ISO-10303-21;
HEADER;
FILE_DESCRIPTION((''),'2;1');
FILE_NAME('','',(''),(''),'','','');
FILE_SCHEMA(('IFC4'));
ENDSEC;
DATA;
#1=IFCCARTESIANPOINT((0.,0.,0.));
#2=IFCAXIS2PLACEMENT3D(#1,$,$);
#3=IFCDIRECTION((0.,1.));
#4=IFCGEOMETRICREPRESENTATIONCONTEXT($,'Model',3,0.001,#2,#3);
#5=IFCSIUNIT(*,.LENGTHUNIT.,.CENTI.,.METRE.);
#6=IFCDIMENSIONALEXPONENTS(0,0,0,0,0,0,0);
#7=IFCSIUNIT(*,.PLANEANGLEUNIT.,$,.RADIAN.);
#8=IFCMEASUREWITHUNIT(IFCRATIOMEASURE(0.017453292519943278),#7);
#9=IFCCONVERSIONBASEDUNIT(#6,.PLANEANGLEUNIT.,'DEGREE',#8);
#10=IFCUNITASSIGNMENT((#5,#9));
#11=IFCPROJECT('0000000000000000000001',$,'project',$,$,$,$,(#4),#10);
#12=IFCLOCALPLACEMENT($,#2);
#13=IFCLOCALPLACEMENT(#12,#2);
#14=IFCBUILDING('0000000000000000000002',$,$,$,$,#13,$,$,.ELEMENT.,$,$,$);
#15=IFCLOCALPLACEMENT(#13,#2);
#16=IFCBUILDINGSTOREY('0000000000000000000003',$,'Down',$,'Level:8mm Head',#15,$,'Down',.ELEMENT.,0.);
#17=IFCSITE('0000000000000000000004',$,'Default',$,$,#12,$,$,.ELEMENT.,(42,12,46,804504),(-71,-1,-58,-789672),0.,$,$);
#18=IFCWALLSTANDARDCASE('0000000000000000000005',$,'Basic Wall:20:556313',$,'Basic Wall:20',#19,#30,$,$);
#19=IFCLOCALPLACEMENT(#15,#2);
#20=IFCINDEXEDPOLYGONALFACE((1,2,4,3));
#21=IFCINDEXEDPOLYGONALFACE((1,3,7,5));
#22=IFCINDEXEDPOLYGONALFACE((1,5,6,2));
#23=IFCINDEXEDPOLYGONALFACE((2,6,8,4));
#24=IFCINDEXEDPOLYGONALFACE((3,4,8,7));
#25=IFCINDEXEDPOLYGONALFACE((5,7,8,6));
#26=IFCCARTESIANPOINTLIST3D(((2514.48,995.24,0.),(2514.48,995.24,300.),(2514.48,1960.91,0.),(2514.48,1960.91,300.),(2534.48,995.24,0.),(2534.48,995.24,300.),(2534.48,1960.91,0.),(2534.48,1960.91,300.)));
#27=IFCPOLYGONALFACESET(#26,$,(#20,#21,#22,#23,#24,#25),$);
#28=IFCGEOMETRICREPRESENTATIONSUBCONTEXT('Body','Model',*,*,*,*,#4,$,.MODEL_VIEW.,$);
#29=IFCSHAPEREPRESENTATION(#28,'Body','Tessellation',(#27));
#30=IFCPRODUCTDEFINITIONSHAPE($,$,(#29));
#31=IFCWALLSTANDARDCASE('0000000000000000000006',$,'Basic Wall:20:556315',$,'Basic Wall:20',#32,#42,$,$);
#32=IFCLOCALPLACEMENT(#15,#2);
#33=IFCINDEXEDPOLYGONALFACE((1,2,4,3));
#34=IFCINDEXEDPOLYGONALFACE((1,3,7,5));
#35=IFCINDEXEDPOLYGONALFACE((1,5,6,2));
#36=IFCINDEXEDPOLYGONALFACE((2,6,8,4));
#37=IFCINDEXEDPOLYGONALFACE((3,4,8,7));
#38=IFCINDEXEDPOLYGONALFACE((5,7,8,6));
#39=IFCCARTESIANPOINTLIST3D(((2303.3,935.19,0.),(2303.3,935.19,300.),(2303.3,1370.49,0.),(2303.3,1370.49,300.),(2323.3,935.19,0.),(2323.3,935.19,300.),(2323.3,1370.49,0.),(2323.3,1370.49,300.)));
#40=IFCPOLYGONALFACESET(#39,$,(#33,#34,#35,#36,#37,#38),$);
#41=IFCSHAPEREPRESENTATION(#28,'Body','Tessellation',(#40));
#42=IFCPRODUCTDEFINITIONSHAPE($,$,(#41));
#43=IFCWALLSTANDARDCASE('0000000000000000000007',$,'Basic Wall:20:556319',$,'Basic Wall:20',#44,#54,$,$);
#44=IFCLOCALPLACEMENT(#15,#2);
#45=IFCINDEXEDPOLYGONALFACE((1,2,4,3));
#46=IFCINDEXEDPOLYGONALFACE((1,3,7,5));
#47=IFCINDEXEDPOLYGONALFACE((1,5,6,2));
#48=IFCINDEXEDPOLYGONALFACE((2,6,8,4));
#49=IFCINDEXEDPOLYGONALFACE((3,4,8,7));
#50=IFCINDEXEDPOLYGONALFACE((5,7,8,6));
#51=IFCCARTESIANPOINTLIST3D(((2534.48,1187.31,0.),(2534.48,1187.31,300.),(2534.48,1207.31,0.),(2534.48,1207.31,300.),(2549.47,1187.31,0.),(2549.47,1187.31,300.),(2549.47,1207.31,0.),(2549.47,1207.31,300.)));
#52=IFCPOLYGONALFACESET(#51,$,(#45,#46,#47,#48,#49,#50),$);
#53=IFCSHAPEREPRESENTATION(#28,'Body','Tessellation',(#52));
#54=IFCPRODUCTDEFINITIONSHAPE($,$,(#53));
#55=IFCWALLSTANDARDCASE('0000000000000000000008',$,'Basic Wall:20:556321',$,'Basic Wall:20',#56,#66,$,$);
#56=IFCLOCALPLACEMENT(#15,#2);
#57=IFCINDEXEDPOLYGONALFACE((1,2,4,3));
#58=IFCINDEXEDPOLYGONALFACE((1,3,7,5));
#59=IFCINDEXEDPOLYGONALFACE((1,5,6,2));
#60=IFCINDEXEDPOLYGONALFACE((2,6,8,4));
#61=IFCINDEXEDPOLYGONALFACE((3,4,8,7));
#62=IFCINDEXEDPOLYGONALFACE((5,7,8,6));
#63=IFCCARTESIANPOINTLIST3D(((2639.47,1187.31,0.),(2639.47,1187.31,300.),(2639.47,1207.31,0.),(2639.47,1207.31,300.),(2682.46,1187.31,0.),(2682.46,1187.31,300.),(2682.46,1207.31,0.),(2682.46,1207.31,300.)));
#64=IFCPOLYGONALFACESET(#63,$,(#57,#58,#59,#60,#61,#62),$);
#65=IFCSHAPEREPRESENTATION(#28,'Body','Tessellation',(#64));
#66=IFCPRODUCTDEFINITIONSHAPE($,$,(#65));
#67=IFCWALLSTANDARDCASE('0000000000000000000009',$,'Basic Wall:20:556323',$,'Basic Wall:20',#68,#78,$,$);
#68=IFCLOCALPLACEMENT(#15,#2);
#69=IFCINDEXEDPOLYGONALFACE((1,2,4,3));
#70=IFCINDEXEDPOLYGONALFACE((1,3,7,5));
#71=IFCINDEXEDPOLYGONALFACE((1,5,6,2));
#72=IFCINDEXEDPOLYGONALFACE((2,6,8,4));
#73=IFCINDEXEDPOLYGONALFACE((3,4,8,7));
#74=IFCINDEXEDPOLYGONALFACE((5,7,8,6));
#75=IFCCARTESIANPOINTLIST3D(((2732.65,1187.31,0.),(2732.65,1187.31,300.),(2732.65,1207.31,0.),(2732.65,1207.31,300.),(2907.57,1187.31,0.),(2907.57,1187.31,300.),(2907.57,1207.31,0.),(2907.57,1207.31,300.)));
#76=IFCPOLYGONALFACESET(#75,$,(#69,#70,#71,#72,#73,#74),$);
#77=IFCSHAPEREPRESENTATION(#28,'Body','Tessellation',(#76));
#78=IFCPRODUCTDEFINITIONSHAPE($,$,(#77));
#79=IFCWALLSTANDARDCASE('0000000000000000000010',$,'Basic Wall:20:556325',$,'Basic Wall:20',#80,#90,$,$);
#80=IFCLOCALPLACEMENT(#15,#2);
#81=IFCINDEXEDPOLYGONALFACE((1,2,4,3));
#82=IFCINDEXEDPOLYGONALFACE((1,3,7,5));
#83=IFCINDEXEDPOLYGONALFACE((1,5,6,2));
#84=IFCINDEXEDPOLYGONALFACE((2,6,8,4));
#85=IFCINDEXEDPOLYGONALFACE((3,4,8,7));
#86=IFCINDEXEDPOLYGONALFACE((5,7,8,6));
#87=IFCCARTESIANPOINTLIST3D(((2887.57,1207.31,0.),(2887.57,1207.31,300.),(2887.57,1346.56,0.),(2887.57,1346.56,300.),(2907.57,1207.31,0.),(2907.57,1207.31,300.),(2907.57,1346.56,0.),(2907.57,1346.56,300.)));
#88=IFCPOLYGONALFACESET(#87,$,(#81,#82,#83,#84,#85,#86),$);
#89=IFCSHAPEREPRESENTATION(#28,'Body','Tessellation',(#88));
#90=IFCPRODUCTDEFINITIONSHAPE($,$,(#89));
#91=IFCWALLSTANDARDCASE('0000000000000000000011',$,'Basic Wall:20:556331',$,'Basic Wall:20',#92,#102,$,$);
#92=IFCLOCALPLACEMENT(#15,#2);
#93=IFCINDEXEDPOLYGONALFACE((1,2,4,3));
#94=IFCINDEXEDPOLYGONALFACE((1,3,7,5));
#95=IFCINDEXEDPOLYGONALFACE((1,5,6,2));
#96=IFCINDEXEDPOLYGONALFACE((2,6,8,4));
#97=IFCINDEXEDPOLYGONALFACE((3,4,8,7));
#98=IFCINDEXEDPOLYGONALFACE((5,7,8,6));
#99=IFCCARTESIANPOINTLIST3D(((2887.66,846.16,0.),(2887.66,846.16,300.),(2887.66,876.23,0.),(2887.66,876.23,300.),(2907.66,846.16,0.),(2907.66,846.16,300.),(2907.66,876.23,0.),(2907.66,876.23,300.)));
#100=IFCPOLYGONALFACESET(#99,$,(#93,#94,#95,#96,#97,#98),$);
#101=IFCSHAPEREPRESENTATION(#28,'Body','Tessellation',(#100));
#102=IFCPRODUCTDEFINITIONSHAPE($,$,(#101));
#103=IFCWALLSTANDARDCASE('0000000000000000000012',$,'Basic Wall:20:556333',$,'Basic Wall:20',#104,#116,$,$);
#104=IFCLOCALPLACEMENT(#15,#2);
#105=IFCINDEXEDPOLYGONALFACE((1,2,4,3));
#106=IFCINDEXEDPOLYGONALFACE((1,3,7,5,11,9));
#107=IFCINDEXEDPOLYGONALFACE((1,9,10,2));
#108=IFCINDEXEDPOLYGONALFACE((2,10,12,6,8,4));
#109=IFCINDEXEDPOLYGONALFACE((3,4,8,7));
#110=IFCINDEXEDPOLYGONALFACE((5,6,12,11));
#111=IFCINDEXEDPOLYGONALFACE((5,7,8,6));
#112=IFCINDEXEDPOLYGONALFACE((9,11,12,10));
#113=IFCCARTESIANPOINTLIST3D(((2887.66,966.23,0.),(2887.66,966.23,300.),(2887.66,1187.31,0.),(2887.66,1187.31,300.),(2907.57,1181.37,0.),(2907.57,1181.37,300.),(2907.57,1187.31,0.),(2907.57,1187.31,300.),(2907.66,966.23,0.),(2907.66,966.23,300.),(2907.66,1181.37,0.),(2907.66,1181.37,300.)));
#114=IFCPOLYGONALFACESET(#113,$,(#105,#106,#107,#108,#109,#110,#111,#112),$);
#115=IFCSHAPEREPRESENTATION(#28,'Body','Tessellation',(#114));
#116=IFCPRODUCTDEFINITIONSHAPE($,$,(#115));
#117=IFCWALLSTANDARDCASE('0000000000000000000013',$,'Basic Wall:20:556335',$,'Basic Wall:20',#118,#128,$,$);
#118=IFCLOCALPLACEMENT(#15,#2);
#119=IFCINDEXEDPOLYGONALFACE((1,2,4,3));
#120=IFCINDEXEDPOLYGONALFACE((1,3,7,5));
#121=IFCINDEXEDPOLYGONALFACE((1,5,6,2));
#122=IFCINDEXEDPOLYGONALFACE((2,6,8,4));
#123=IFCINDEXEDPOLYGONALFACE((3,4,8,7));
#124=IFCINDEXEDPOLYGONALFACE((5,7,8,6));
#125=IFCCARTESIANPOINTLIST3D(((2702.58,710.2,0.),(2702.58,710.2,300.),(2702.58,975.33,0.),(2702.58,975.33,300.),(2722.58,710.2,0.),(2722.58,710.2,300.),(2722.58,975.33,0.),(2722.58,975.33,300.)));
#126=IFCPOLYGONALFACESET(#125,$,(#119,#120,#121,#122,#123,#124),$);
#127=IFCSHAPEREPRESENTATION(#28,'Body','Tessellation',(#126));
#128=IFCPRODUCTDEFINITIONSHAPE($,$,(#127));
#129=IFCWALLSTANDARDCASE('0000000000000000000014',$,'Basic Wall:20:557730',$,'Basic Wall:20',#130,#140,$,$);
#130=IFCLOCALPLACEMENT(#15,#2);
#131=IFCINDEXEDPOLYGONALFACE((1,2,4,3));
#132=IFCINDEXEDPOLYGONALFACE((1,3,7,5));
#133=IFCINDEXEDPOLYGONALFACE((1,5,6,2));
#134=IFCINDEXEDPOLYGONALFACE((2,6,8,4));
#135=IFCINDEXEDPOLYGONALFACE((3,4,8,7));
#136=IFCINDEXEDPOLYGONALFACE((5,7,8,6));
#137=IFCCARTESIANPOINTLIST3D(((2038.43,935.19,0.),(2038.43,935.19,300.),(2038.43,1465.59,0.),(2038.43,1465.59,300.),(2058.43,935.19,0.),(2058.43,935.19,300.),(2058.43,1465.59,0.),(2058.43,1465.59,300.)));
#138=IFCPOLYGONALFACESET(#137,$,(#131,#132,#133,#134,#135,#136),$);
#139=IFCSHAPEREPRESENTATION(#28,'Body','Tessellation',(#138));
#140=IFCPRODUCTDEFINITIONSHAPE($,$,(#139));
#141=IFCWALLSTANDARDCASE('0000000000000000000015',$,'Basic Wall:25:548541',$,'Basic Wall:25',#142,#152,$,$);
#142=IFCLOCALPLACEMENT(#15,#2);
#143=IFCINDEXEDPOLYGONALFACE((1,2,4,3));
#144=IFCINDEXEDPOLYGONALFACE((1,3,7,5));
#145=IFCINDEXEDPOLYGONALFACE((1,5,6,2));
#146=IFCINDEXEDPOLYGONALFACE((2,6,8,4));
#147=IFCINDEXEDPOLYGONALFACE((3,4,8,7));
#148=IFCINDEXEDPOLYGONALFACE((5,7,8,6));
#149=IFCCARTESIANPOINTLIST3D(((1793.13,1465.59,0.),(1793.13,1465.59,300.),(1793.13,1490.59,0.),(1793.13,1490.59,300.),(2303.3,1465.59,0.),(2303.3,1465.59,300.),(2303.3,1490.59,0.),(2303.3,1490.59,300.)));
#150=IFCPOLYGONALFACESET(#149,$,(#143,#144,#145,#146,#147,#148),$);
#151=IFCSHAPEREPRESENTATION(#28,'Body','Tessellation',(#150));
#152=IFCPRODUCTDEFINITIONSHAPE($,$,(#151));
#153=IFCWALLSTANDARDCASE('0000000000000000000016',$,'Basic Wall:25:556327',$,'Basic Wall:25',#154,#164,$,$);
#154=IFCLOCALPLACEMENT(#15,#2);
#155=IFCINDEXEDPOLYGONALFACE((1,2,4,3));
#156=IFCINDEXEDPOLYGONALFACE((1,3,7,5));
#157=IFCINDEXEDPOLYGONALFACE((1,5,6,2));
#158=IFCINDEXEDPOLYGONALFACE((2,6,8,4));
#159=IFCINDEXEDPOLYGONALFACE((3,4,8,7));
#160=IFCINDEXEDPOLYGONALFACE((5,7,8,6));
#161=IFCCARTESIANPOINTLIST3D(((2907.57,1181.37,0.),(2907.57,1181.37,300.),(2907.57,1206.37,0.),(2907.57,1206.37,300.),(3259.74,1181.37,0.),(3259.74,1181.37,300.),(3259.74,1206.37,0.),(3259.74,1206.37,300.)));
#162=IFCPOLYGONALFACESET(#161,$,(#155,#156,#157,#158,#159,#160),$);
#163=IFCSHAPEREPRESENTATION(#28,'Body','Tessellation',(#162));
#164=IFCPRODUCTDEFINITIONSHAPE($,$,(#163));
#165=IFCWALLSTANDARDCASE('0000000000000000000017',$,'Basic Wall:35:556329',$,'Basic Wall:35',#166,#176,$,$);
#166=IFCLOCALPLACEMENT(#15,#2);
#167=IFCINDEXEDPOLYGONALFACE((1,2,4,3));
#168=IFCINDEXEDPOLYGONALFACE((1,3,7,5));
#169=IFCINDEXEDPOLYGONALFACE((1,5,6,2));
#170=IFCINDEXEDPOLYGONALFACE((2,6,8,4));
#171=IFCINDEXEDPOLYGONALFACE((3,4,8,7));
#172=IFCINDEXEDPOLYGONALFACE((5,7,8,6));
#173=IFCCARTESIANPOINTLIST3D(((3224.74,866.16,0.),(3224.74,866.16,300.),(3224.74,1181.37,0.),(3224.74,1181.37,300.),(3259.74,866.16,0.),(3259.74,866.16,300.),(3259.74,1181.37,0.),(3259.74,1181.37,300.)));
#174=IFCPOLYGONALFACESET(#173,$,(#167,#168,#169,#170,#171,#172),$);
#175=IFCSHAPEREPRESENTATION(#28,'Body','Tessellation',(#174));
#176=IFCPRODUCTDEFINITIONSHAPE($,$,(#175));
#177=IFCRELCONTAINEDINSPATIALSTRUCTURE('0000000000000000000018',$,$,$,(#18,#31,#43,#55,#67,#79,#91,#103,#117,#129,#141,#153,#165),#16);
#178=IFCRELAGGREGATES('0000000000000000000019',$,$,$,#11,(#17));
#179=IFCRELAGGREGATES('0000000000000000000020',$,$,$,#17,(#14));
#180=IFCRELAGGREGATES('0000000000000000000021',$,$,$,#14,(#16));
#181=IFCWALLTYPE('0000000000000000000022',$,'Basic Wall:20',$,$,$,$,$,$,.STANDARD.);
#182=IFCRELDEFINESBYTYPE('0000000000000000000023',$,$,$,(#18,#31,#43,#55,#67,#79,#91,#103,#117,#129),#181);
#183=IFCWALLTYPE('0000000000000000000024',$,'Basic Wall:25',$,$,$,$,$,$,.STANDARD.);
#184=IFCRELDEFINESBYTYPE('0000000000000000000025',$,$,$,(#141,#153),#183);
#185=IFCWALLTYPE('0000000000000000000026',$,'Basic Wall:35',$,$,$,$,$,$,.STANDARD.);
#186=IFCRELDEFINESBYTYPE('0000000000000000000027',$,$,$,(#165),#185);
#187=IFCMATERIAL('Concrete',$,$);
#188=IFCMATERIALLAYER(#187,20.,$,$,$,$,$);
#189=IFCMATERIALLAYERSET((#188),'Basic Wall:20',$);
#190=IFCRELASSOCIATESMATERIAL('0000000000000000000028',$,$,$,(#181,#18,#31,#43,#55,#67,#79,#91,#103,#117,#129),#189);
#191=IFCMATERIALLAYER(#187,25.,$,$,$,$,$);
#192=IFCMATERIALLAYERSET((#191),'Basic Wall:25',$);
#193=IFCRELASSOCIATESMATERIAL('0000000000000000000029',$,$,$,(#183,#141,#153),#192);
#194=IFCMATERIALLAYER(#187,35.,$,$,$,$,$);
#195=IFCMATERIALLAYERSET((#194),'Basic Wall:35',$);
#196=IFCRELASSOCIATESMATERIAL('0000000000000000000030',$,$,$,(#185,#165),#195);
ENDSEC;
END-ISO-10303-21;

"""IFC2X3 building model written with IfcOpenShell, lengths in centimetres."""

from ifc_helpers import new_model, entity, si_unit, converted_unit, direction, frame, frame_2d, origin, place, context, subcontext, project, spatial, polyline, rectangle, outline, extrude, material, layer, layer_set, layer_usage, type_object, element, save


model = new_model("IFC2X3")

# Units and contexts
model_context = context("Model", 3, precision=0.001, world=origin(), true_north=direction((0.0, 1.0)))
body_context = subcontext(model_context, "Body", "Model", "MODEL_VIEW")
ifc_project = project(units=[si_unit("LENGTHUNIT", "METRE", prefix="CENTI"), converted_unit("PLANEANGLEUNIT", "DEGREE", entity("IfcRatioMeasure", 0.017453292519943278), si_unit("PLANEANGLEUNIT", "RADIAN"), dimensions=[0, 0, 0, 0, 0, 0, 0])], contexts=[model_context])

# Site, building, storey
site_placement = place(None, origin())
site = spatial("IfcSite", under=ifc_project, at=site_placement, Name="Default", CompositionType="ELEMENT", RefLatitude=(42, 12, 46, 804504), RefLongitude=(-71, -1, -58, -789672), RefElevation=0.0)
building_placement = place(site_placement, origin())
building = spatial("IfcBuilding", under=site, at=building_placement, CompositionType="ELEMENT")
storey_placement = place(building_placement, origin())
storey = spatial("IfcBuildingStorey", under=building, at=storey_placement, Name="Down", ObjectType="Level:8mm Head", LongName="Down", CompositionType="ELEMENT", Elevation=0.0)

# Walls
ifc_material = material(Name="Concrete")
ifc_layer_1 = layer(ifc_material, 20.0)
ifc_layer_set_1 = layer_set([ifc_layer_1], Name="Basic Wall:20")
wall_type_1 = type_object("IfcWallType", Name="Basic Wall:20", PredefinedType="STANDARD", material=ifc_layer_set_1)
ifc_layer_usage_1 = layer_usage(ifc_layer_set_1, "AXIS2", "POSITIVE", -10.0)
wall_1_placement = place(storey_placement, frame((2524.48, 995.24, 0.0), z_axis=(0.0, 0.0, 1.0), x_axis=(0.0, 1.0, 0.0)))
element("IfcWallStandardCase", 1, at=wall_1_placement, inside=storey, type_object=wall_type_1, material=ifc_layer_usage_1, Name="Basic Wall:20:556313", ObjectType="Basic Wall:20", context=body_context, shape_type="SweptSolid", body=[
    extrude(rectangle(XDim=965.67, YDim=20.0, at=frame_2d((482.83, 0.0), x_axis=(-1.0, 0.0))), origin(), (0.0, 0.0, 1.0), 300.0),
])
ifc_layer_usage_2 = layer_usage(ifc_layer_set_1, "AXIS2", "NEGATIVE", 10.0)
wall_2_placement = place(storey_placement, frame((2313.3, 1370.49, 0.0), z_axis=(0.0, 0.0, 1.0), x_axis=(0.0, -1.0, 0.0)))
element("IfcWallStandardCase", 2, at=wall_2_placement, inside=storey, type_object=wall_type_1, material=ifc_layer_usage_2, Name="Basic Wall:20:556315", ObjectType="Basic Wall:20", context=body_context, shape_type="SweptSolid", body=[
    extrude(rectangle(XDim=435.3, YDim=20.0, at=frame_2d((217.65, 0.0), x_axis=(-1.0, 0.0))), origin(), (0.0, 0.0, 1.0), 300.0),
])
ifc_layer_usage_3 = layer_usage(ifc_layer_set_1, "AXIS2", "POSITIVE", -10.0)
wall_3_placement = place(storey_placement, frame((2534.48, 1197.31, 0.0)))
element("IfcWallStandardCase", 3, at=wall_3_placement, inside=storey, type_object=wall_type_1, material=ifc_layer_usage_3, Name="Basic Wall:20:556319", ObjectType="Basic Wall:20", context=body_context, shape_type="SweptSolid", body=[
    extrude(rectangle(XDim=14.99, YDim=20.0, at=frame_2d((7.49, 0.0), x_axis=(-1.0, 0.0))), origin(), (0.0, 0.0, 1.0), 300.0),
])
ifc_layer_usage_4 = layer_usage(ifc_layer_set_1, "AXIS2", "POSITIVE", -10.0)
wall_4_placement = place(storey_placement, frame((2639.47, 1197.31, 0.0)))
element("IfcWallStandardCase", 4, at=wall_4_placement, inside=storey, type_object=wall_type_1, material=ifc_layer_usage_4, Name="Basic Wall:20:556321", ObjectType="Basic Wall:20", context=body_context, shape_type="SweptSolid", body=[
    extrude(rectangle(XDim=42.99, YDim=20.0, at=frame_2d((21.49, 0.0), x_axis=(-1.0, 0.0))), origin(), (0.0, 0.0, 1.0), 300.0),
])
ifc_layer_usage_5 = layer_usage(ifc_layer_set_1, "AXIS2", "POSITIVE", -10.0)
wall_5_placement = place(storey_placement, frame((2732.65, 1197.31, 0.0)))
element("IfcWallStandardCase", 5, at=wall_5_placement, inside=storey, type_object=wall_type_1, material=ifc_layer_usage_5, Name="Basic Wall:20:556323", ObjectType="Basic Wall:20", context=body_context, shape_type="SweptSolid", body=[
    extrude(rectangle(XDim=174.92, YDim=20.0, at=frame_2d((87.46, 0.0), x_axis=(-1.0, 0.0))), origin(), (0.0, 0.0, 1.0), 300.0),
])
ifc_layer_usage_6 = layer_usage(ifc_layer_set_1, "AXIS2", "POSITIVE", -10.0)
wall_6_placement = place(storey_placement, frame((2897.57, 1207.31, 0.0), z_axis=(0.0, 0.0, 1.0), x_axis=(0.0, 1.0, 0.0)))
element("IfcWallStandardCase", 6, at=wall_6_placement, inside=storey, type_object=wall_type_1, material=ifc_layer_usage_6, Name="Basic Wall:20:556325", ObjectType="Basic Wall:20", context=body_context, shape_type="SweptSolid", body=[
    extrude(rectangle(XDim=139.25, YDim=20.0, at=frame_2d((69.62, 0.0), x_axis=(-1.0, 0.0))), origin(), (0.0, 0.0, 1.0), 300.0),
])
ifc_layer_usage_7 = layer_usage(ifc_layer_set_1, "AXIS2", "NEGATIVE", 10.0)
wall_7_placement = place(storey_placement, frame((2897.66, 846.16, 0.0), z_axis=(0.0, 0.0, 1.0), x_axis=(0.0, 1.0, 0.0)))
element("IfcWallStandardCase", 7, at=wall_7_placement, inside=storey, type_object=wall_type_1, material=ifc_layer_usage_7, Name="Basic Wall:20:556331", ObjectType="Basic Wall:20", context=body_context, shape_type="SweptSolid", body=[
    extrude(rectangle(XDim=30.07, YDim=20.0, at=frame_2d((15.04, 0.0), x_axis=(-1.0, 0.0))), origin(), (0.0, 0.0, 1.0), 300.0),
])
ifc_layer_usage_8 = layer_usage(ifc_layer_set_1, "AXIS2", "NEGATIVE", 10.0)
wall_8_placement = place(storey_placement, frame((2897.66, 966.23, 0.0), z_axis=(0.0, 0.0, 1.0), x_axis=(0.0, 1.0, 0.0)))
element("IfcWallStandardCase", 8, at=wall_8_placement, inside=storey, type_object=wall_type_1, material=ifc_layer_usage_8, Name="Basic Wall:20:556333", ObjectType="Basic Wall:20", context=body_context, shape_type="SweptSolid", body=[
    extrude(outline(polyline([(215.14, -10.0), (215.14, -9.91), (221.08, -9.91), (221.08, 10.0), (0.0, 10.0), (0.0, -10.0), (215.14, -10.0)])), origin(), (0.0, 0.0, 1.0), 300.0),
])
ifc_layer_usage_9 = layer_usage(ifc_layer_set_1, "AXIS2", "POSITIVE", -10.0)
wall_9_placement = place(storey_placement, frame((2712.58, 975.33, 0.0), z_axis=(0.0, 0.0, 1.0), x_axis=(0.0, -1.0, 0.0)))
element("IfcWallStandardCase", 9, at=wall_9_placement, inside=storey, type_object=wall_type_1, material=ifc_layer_usage_9, Name="Basic Wall:20:556335", ObjectType="Basic Wall:20", context=body_context, shape_type="SweptSolid", body=[
    extrude(rectangle(XDim=265.13, YDim=20.0, at=frame_2d((132.57, 0.0), x_axis=(-1.0, 0.0))), origin(), (0.0, 0.0, 1.0), 300.0),
])
ifc_layer_usage_10 = layer_usage(ifc_layer_set_1, "AXIS2", "POSITIVE", -10.0)
wall_10_placement = place(storey_placement, frame((2048.43, 1465.59, 0.0), z_axis=(0.0, 0.0, 1.0), x_axis=(0.0, -1.0, 0.0)))
element("IfcWallStandardCase", 10, at=wall_10_placement, inside=storey, type_object=wall_type_1, material=ifc_layer_usage_10, Name="Basic Wall:20:557730", ObjectType="Basic Wall:20", context=body_context, shape_type="SweptSolid", body=[
    extrude(rectangle(XDim=530.39, YDim=20.0, at=frame_2d((265.2, 0.0), x_axis=(-1.0, 0.0))), origin(), (0.0, 0.0, 1.0), 300.0),
])
ifc_layer_2 = layer(ifc_material, 25.0)
ifc_layer_set_2 = layer_set([ifc_layer_2], Name="Basic Wall:25")
ifc_layer_usage_11 = layer_usage(ifc_layer_set_2, "AXIS2", "NEGATIVE", 12.5)
wall_type_2 = type_object("IfcWallType", Name="Basic Wall:25", PredefinedType="STANDARD", material=ifc_layer_set_2)
wall_11_placement = place(storey_placement, frame((2303.3, 1478.09, 0.0), z_axis=(0.0, 0.0, 1.0), x_axis=(-1.0, 0.0, 0.0)))
element("IfcWallStandardCase", 11, at=wall_11_placement, inside=storey, type_object=wall_type_2, material=ifc_layer_usage_11, Name="Basic Wall:25:548541", ObjectType="Basic Wall:25", context=body_context, shape_type="SweptSolid", body=[
    extrude(rectangle(XDim=510.17, YDim=25.0, at=frame_2d((255.09, 0.0), x_axis=(-1.0, 0.0))), origin(), (0.0, 0.0, 1.0), 300.0),
])
ifc_layer_usage_12 = layer_usage(ifc_layer_set_2, "AXIS2", "NEGATIVE", 12.5)
wall_12_placement = place(storey_placement, frame((2907.57, 1193.87, 0.0)))
element("IfcWallStandardCase", 12, at=wall_12_placement, inside=storey, type_object=wall_type_2, material=ifc_layer_usage_12, Name="Basic Wall:25:556327", ObjectType="Basic Wall:25", context=body_context, shape_type="SweptSolid", body=[
    extrude(rectangle(XDim=352.17, YDim=25.0, at=frame_2d((176.08, 0.0), x_axis=(-1.0, 0.0))), origin(), (0.0, 0.0, 1.0), 300.0),
])
ifc_layer_3 = layer(ifc_material, 35.0)
ifc_layer_set_3 = layer_set([ifc_layer_3], Name="Basic Wall:35")
ifc_layer_usage_13 = layer_usage(ifc_layer_set_3, "AXIS2", "NEGATIVE", 17.5)
wall_type_3 = type_object("IfcWallType", Name="Basic Wall:35", PredefinedType="STANDARD", material=ifc_layer_set_3)
wall_13_placement = place(storey_placement, frame((3242.24, 1181.37, 0.0), z_axis=(0.0, 0.0, 1.0), x_axis=(0.0, -1.0, 0.0)))
element("IfcWallStandardCase", 13, at=wall_13_placement, inside=storey, type_object=wall_type_3, material=ifc_layer_usage_13, Name="Basic Wall:35:556329", ObjectType="Basic Wall:35", context=body_context, shape_type="SweptSolid", body=[
    extrude(rectangle(XDim=315.22, YDim=35.0, at=frame_2d((157.61, 0.0), x_axis=(-1.0, 0.0))), origin(), (0.0, 0.0, 1.0), 300.0),
])

save(model, "model.ifc")
